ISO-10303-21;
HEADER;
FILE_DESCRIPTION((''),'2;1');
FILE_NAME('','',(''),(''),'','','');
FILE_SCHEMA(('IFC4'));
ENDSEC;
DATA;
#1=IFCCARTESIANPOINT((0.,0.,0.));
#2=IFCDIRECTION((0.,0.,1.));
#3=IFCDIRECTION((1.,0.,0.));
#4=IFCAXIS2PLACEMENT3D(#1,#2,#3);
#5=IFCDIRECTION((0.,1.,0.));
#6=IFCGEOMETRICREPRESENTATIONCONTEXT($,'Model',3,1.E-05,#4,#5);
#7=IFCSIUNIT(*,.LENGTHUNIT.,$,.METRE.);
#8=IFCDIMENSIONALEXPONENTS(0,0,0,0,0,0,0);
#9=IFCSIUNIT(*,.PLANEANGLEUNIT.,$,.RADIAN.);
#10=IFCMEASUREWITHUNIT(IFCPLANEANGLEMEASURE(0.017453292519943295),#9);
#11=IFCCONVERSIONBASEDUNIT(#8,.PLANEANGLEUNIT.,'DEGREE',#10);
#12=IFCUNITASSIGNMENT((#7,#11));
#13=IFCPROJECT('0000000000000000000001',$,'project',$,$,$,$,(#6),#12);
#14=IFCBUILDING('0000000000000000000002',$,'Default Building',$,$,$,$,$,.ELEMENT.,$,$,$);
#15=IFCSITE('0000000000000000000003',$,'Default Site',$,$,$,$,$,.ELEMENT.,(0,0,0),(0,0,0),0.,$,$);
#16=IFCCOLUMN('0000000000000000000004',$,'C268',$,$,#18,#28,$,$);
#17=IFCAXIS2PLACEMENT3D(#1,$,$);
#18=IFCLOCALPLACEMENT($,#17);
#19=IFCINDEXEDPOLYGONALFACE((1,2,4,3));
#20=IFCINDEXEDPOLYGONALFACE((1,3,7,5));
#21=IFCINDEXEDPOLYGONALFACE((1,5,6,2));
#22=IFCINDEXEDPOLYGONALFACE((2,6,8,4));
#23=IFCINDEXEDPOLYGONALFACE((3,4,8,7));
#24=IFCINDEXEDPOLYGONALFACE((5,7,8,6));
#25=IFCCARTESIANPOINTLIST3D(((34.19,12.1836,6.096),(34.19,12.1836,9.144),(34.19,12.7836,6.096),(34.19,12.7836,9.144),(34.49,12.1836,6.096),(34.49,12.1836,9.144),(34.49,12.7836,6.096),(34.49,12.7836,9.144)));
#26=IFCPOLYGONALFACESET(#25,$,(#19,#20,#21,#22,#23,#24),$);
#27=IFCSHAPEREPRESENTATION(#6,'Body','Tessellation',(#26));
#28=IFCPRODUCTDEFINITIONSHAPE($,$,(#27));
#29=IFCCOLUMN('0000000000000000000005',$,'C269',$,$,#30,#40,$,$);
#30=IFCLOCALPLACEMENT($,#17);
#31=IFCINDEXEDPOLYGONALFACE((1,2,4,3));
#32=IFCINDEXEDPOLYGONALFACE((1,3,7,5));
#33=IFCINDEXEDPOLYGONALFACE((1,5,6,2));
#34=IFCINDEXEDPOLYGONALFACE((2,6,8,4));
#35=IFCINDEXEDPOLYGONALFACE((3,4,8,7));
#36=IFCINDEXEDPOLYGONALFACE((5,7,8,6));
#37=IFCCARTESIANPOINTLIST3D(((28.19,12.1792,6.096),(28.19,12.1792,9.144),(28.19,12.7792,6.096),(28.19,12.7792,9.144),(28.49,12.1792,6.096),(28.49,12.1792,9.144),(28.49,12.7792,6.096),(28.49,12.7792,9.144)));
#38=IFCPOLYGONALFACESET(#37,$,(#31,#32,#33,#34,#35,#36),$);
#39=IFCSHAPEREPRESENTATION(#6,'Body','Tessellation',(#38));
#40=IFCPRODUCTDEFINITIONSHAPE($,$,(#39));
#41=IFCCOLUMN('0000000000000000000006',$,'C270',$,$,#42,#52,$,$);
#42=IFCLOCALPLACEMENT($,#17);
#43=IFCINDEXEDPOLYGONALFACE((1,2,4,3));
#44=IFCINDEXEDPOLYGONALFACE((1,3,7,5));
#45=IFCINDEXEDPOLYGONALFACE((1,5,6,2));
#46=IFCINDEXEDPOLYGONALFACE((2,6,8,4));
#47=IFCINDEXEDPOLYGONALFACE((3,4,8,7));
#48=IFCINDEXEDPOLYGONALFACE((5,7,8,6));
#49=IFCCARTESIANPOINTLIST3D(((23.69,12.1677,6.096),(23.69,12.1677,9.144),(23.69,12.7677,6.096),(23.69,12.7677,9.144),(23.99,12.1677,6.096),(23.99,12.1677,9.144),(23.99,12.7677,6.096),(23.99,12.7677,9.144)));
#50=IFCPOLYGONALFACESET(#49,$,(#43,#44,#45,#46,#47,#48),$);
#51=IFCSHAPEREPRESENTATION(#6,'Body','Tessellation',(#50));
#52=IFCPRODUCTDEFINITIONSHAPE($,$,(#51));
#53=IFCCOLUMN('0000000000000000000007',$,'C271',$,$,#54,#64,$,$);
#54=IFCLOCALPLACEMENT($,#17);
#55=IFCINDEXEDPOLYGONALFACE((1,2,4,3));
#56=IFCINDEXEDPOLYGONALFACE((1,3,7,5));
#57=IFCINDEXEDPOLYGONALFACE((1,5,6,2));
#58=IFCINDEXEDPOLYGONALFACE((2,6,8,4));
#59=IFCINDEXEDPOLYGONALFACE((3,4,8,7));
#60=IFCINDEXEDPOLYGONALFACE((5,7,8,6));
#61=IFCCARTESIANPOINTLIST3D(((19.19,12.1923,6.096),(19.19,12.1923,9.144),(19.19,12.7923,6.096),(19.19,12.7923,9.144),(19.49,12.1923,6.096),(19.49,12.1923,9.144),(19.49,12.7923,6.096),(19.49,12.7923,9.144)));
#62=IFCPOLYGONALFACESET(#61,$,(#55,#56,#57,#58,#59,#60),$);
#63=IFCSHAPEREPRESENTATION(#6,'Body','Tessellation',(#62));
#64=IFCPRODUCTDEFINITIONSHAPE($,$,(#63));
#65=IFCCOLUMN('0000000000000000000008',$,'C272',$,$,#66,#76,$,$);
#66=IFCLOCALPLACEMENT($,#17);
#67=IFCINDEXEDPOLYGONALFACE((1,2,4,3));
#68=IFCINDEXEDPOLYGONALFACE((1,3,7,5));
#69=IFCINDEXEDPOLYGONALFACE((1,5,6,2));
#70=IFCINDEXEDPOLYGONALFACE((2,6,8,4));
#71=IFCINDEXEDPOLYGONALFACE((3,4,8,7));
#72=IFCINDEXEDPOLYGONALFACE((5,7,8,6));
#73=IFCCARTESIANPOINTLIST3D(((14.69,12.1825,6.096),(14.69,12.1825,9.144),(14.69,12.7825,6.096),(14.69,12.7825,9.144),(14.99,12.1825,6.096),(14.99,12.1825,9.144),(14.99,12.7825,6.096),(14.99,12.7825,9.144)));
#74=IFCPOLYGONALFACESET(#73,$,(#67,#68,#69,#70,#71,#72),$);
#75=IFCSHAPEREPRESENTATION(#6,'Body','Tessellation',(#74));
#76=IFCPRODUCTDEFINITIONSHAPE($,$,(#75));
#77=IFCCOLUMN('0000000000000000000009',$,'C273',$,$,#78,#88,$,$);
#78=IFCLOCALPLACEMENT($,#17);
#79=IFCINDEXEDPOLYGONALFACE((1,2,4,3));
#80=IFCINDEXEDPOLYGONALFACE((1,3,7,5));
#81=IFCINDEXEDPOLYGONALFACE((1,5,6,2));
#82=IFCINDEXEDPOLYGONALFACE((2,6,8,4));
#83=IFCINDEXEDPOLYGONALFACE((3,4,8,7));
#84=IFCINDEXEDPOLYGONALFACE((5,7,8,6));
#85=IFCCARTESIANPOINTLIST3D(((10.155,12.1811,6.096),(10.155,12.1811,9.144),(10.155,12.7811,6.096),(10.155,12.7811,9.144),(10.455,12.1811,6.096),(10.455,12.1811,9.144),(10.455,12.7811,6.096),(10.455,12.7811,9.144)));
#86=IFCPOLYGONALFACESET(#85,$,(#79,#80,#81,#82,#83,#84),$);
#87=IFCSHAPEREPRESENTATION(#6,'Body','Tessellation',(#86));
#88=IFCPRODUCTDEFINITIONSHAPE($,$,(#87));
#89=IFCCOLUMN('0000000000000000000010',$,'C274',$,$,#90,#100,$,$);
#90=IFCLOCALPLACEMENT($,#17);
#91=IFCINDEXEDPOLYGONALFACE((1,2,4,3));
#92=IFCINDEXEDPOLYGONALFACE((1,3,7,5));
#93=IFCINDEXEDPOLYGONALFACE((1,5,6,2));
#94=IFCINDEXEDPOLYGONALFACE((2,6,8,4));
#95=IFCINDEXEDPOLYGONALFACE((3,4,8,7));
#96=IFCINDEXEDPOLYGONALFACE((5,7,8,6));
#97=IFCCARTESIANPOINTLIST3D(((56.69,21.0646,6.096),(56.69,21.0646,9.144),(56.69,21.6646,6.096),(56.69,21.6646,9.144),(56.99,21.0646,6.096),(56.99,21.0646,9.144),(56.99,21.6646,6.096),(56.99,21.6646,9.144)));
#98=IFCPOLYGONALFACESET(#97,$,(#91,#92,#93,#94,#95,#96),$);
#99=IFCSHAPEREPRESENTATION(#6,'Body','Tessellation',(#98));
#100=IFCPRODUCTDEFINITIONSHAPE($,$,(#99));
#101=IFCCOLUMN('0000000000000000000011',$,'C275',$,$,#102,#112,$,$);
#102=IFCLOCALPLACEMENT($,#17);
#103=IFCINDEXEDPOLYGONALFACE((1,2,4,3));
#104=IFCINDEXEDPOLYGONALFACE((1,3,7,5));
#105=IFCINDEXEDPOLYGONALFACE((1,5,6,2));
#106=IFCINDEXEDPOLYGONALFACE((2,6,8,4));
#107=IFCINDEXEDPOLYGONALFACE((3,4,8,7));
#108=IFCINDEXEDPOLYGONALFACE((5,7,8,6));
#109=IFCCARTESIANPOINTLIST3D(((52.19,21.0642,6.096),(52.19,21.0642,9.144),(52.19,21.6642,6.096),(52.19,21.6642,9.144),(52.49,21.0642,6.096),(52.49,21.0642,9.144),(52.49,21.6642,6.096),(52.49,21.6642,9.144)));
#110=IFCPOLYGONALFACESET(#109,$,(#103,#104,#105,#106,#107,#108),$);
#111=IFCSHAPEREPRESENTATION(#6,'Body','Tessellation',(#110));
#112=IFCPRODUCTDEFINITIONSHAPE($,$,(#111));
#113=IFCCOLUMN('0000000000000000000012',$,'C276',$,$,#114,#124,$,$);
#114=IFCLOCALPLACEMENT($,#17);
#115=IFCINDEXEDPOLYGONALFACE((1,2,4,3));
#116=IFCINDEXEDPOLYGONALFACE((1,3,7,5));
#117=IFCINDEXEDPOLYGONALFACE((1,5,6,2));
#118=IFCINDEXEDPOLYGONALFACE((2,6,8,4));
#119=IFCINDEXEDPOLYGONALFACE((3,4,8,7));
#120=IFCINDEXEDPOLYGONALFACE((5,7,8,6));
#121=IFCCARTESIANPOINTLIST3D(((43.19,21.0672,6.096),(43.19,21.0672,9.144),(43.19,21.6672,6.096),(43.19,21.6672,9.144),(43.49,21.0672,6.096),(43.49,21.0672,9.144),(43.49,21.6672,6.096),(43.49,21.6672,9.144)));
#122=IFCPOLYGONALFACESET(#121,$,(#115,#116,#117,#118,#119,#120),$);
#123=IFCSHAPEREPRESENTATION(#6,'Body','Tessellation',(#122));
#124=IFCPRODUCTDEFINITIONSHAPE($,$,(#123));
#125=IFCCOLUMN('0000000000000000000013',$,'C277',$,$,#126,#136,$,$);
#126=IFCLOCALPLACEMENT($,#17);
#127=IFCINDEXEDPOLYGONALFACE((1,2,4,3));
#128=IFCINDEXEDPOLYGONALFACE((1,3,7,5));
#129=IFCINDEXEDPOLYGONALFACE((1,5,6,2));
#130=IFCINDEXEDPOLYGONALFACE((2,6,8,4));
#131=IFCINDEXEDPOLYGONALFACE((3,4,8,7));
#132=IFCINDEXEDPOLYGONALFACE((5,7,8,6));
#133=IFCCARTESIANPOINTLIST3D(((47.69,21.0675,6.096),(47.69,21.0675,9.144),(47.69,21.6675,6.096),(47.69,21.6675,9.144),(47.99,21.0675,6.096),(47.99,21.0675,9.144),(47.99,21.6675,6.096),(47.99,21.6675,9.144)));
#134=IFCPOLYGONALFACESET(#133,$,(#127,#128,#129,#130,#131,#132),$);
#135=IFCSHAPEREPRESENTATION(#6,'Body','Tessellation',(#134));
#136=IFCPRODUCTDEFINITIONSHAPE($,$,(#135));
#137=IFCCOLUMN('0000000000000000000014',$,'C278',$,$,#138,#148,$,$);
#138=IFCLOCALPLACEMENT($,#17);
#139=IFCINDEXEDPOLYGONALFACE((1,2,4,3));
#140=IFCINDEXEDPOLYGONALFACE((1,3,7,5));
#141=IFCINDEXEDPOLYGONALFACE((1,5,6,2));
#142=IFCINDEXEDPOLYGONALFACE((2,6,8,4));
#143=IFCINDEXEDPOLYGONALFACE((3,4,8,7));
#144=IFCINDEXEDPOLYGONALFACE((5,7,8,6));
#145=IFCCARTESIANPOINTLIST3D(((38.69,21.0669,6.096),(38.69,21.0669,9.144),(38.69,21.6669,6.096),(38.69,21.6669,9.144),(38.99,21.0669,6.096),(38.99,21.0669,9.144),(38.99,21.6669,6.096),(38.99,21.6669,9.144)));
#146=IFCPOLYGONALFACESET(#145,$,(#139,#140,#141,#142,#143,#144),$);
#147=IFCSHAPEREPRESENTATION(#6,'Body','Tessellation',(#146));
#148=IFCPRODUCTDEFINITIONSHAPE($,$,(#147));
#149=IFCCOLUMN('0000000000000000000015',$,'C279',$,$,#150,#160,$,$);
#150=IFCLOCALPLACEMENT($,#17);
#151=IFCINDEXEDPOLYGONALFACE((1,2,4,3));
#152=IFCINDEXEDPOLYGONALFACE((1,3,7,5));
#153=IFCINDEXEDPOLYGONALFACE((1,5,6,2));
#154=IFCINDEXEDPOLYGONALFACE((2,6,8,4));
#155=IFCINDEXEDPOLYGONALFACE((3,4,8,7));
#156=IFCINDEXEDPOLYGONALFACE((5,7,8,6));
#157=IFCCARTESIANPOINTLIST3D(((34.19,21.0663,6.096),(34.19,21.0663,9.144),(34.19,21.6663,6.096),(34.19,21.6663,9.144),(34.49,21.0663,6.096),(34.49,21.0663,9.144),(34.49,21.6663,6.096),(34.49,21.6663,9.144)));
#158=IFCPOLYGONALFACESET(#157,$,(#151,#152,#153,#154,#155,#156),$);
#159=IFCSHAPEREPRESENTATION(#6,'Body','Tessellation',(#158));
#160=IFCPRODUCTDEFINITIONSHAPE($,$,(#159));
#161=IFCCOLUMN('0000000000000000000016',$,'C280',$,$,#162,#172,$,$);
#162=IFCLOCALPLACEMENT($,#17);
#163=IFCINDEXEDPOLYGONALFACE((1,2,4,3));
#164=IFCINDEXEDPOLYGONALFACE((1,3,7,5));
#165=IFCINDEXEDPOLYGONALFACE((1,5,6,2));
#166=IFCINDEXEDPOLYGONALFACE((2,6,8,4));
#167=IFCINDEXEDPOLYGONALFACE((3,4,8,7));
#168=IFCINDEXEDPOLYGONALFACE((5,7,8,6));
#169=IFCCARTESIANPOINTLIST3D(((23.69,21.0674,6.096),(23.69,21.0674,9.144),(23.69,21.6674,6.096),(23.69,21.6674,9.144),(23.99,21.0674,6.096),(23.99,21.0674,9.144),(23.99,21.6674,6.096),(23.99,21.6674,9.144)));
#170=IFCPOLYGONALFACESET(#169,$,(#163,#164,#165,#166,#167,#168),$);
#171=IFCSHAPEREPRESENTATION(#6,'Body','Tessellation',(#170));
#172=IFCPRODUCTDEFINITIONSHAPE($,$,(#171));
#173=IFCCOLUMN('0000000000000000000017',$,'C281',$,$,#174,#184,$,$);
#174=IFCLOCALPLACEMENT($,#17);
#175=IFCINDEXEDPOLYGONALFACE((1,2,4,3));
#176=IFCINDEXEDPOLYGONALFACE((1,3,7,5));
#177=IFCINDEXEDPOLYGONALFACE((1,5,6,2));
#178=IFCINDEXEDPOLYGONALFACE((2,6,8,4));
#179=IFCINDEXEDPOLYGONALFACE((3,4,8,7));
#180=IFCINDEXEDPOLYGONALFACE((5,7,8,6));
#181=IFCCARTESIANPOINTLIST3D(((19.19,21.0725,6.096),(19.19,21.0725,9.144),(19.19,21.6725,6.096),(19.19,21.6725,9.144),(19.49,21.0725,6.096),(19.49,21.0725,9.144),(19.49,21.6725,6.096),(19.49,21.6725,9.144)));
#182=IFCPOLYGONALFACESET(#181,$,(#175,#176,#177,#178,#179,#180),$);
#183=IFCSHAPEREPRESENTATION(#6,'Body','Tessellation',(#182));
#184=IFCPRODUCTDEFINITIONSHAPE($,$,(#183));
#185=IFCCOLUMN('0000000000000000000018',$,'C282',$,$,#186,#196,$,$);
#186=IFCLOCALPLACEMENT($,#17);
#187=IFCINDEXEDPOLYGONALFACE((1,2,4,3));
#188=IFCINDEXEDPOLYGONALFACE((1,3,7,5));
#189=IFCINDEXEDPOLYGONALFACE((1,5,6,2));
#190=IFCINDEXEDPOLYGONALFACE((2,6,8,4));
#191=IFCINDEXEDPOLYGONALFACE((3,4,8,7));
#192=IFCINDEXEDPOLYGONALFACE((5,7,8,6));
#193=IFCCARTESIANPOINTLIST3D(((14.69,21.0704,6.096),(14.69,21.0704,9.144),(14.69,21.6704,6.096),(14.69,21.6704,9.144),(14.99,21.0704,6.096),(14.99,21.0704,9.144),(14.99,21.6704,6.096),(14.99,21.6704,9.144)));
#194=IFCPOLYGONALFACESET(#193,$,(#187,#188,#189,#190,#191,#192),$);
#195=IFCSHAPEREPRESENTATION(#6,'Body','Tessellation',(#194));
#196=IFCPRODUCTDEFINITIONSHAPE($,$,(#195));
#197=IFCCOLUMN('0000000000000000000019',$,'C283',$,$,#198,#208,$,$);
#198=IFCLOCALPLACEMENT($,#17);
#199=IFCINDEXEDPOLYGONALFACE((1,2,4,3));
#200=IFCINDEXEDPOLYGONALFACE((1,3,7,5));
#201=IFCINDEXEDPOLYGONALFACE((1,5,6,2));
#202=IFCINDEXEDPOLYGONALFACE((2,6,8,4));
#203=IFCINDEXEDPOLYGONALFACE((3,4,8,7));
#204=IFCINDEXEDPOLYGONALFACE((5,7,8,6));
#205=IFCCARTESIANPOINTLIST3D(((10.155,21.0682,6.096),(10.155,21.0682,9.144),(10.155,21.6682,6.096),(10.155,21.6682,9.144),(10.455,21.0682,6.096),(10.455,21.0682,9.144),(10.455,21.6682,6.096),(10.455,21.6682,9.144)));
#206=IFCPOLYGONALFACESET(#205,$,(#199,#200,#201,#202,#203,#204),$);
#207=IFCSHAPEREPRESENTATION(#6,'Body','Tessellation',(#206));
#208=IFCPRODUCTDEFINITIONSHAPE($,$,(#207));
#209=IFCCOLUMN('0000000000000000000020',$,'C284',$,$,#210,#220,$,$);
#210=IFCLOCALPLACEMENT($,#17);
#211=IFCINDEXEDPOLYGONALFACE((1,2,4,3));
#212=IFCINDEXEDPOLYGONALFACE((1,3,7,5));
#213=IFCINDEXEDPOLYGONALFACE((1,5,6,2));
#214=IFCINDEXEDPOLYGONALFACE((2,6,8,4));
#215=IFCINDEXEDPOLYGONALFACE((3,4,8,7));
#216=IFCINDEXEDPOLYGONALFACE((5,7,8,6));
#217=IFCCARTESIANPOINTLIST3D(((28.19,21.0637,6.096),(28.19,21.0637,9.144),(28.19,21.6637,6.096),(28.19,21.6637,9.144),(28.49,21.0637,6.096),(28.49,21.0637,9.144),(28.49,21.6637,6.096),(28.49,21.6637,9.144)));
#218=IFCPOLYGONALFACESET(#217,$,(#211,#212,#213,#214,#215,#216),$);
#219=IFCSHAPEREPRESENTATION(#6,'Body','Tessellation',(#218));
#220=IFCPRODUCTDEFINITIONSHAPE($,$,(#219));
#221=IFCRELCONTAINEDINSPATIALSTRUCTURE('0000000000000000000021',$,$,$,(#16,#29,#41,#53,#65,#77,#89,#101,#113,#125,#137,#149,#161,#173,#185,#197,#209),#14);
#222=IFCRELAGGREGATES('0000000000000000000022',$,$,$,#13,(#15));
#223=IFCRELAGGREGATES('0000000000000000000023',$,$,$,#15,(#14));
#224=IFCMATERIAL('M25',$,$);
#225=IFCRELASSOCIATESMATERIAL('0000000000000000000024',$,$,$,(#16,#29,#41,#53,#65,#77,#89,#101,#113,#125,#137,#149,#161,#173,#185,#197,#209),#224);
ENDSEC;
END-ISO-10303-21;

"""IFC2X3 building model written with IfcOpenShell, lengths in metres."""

from ifc_helpers import new_model, entity, si_unit, converted_unit, direction, frame, frame_2d, origin_with_axes, place, context, project, spatial, rectangle, extrude, material, element, save


model = new_model("IFC2X3")

# Units and contexts
model_context = context("Model", 3, precision=1e-05, world=origin_with_axes(), true_north=direction((0.0, 1.0, 0.0)))
ifc_project = project(units=[si_unit("LENGTHUNIT", "METRE"), converted_unit("PLANEANGLEUNIT", "DEGREE", entity("IfcPlaneAngleMeasure", 0.017453292519943295), si_unit("PLANEANGLEUNIT", "RADIAN"), dimensions=[0, 0, 0, 0, 0, 0, 0])], contexts=[model_context])

# Site, building
site = spatial("IfcSite", under=ifc_project, Name="Default Site", CompositionType="ELEMENT", RefLatitude=(0, 0, 0), RefLongitude=(0, 0, 0), RefElevation=0.0)
building = spatial("IfcBuilding", under=site, Name="Default Building", CompositionType="ELEMENT")

# Columns
ifc_material = material(Name="M25")
placement = place(None, origin_with_axes())
element("IfcColumn", 1, at=placement, inside=building, material=ifc_material, Name="C268", context=model_context, shape_type="SweptSolid", body=[
    extrude(rectangle(XDim=0.3, YDim=0.6, at=frame_2d((0.0, 0.0), x_axis=(1.0, 0.0, 0.0))), frame((34.34, 12.4836, 6.096), z_axis=(0.0, 0.0, 1.0), x_axis=(1.0, 0.0, 0.0)), (0.0, 0.0, 1.0), 3.048),
])
element("IfcColumn", 2, at=placement, inside=building, material=ifc_material, Name="C269", context=model_context, shape_type="SweptSolid", body=[
    extrude(rectangle(XDim=0.3, YDim=0.6, at=frame_2d((0.0, 0.0), x_axis=(1.0, 0.0, 0.0))), frame((28.34, 12.4792, 6.096), z_axis=(0.0, 0.0, 1.0), x_axis=(1.0, 0.0, 0.0)), (0.0, 0.0, 1.0), 3.048),
])
element("IfcColumn", 3, at=placement, inside=building, material=ifc_material, Name="C270", context=model_context, shape_type="SweptSolid", body=[
    extrude(rectangle(XDim=0.3, YDim=0.6, at=frame_2d((0.0, 0.0), x_axis=(1.0, 0.0, 0.0))), frame((23.84, 12.4677, 6.096), z_axis=(0.0, 0.0, 1.0), x_axis=(1.0, 0.0, 0.0)), (0.0, 0.0, 1.0), 3.048),
])
element("IfcColumn", 4, at=placement, inside=building, material=ifc_material, Name="C271", context=model_context, shape_type="SweptSolid", body=[
    extrude(rectangle(XDim=0.3, YDim=0.6, at=frame_2d((0.0, 0.0), x_axis=(1.0, 0.0, 0.0))), frame((19.34, 12.4923, 6.096), z_axis=(0.0, 0.0, 1.0), x_axis=(1.0, 0.0, 0.0)), (0.0, 0.0, 1.0), 3.048),
])
element("IfcColumn", 5, at=placement, inside=building, material=ifc_material, Name="C272", context=model_context, shape_type="SweptSolid", body=[
    extrude(rectangle(XDim=0.3, YDim=0.6, at=frame_2d((0.0, 0.0), x_axis=(1.0, 0.0, 0.0))), frame((14.84, 12.4825, 6.096), z_axis=(0.0, 0.0, 1.0), x_axis=(1.0, 0.0, 0.0)), (0.0, 0.0, 1.0), 3.048),
])
element("IfcColumn", 6, at=placement, inside=building, material=ifc_material, Name="C273", context=model_context, shape_type="SweptSolid", body=[
    extrude(rectangle(XDim=0.3, YDim=0.6, at=frame_2d((0.0, 0.0), x_axis=(1.0, 0.0, 0.0))), frame((10.305, 12.4811, 6.096), z_axis=(0.0, 0.0, 1.0), x_axis=(1.0, 0.0, 0.0)), (0.0, 0.0, 1.0), 3.048),
])
element("IfcColumn", 7, at=placement, inside=building, material=ifc_material, Name="C274", context=model_context, shape_type="SweptSolid", body=[
    extrude(rectangle(XDim=0.3, YDim=0.6, at=frame_2d((0.0, 0.0), x_axis=(1.0, 0.0, 0.0))), frame((56.84, 21.3646, 6.096), z_axis=(0.0, 0.0, 1.0), x_axis=(1.0, 0.0, 0.0)), (0.0, 0.0, 1.0), 3.048),
])
element("IfcColumn", 8, at=placement, inside=building, material=ifc_material, Name="C275", context=model_context, shape_type="SweptSolid", body=[
    extrude(rectangle(XDim=0.3, YDim=0.6, at=frame_2d((0.0, 0.0), x_axis=(1.0, 0.0, 0.0))), frame((52.34, 21.3642, 6.096), z_axis=(0.0, 0.0, 1.0), x_axis=(1.0, 0.0, 0.0)), (0.0, 0.0, 1.0), 3.048),
])
element("IfcColumn", 9, at=placement, inside=building, material=ifc_material, Name="C276", context=model_context, shape_type="SweptSolid", body=[
    extrude(rectangle(XDim=0.3, YDim=0.6, at=frame_2d((0.0, 0.0), x_axis=(1.0, 0.0, 0.0))), frame((43.34, 21.3672, 6.096), z_axis=(0.0, 0.0, 1.0), x_axis=(1.0, 0.0, 0.0)), (0.0, 0.0, 1.0), 3.048),
])
element("IfcColumn", 10, at=placement, inside=building, material=ifc_material, Name="C277", context=model_context, shape_type="SweptSolid", body=[
    extrude(rectangle(XDim=0.3, YDim=0.6, at=frame_2d((0.0, 0.0), x_axis=(1.0, 0.0, 0.0))), frame((47.84, 21.3675, 6.096), z_axis=(0.0, 0.0, 1.0), x_axis=(1.0, 0.0, 0.0)), (0.0, 0.0, 1.0), 3.048),
])
element("IfcColumn", 11, at=placement, inside=building, material=ifc_material, Name="C278", context=model_context, shape_type="SweptSolid", body=[
    extrude(rectangle(XDim=0.3, YDim=0.6, at=frame_2d((0.0, 0.0), x_axis=(1.0, 0.0, 0.0))), frame((38.84, 21.3669, 6.096), z_axis=(0.0, 0.0, 1.0), x_axis=(1.0, 0.0, 0.0)), (0.0, 0.0, 1.0), 3.048),
])
element("IfcColumn", 12, at=placement, inside=building, material=ifc_material, Name="C279", context=model_context, shape_type="SweptSolid", body=[
    extrude(rectangle(XDim=0.3, YDim=0.6, at=frame_2d((0.0, 0.0), x_axis=(1.0, 0.0, 0.0))), frame((34.34, 21.3663, 6.096), z_axis=(0.0, 0.0, 1.0), x_axis=(1.0, 0.0, 0.0)), (0.0, 0.0, 1.0), 3.048),
])
element("IfcColumn", 13, at=placement, inside=building, material=ifc_material, Name="C280", context=model_context, shape_type="SweptSolid", body=[
    extrude(rectangle(XDim=0.3, YDim=0.6, at=frame_2d((0.0, 0.0), x_axis=(1.0, 0.0, 0.0))), frame((23.84, 21.3674, 6.096), z_axis=(0.0, 0.0, 1.0), x_axis=(1.0, 0.0, 0.0)), (0.0, 0.0, 1.0), 3.048),
])
element("IfcColumn", 14, at=placement, inside=building, material=ifc_material, Name="C281", context=model_context, shape_type="SweptSolid", body=[
    extrude(rectangle(XDim=0.3, YDim=0.6, at=frame_2d((0.0, 0.0), x_axis=(1.0, 0.0, 0.0))), frame((19.34, 21.3725, 6.096), z_axis=(0.0, 0.0, 1.0), x_axis=(1.0, 0.0, 0.0)), (0.0, 0.0, 1.0), 3.048),
])
element("IfcColumn", 15, at=placement, inside=building, material=ifc_material, Name="C282", context=model_context, shape_type="SweptSolid", body=[
    extrude(rectangle(XDim=0.3, YDim=0.6, at=frame_2d((0.0, 0.0), x_axis=(1.0, 0.0, 0.0))), frame((14.84, 21.3704, 6.096), z_axis=(0.0, 0.0, 1.0), x_axis=(1.0, 0.0, 0.0)), (0.0, 0.0, 1.0), 3.048),
])
element("IfcColumn", 16, at=placement, inside=building, material=ifc_material, Name="C283", context=model_context, shape_type="SweptSolid", body=[
    extrude(rectangle(XDim=0.3, YDim=0.6, at=frame_2d((0.0, 0.0), x_axis=(1.0, 0.0, 0.0))), frame((10.305, 21.3682, 6.096), z_axis=(0.0, 0.0, 1.0), x_axis=(1.0, 0.0, 0.0)), (0.0, 0.0, 1.0), 3.048),
])
element("IfcColumn", 17, at=placement, inside=building, material=ifc_material, Name="C284", context=model_context, shape_type="SweptSolid", body=[
    extrude(rectangle(XDim=0.3, YDim=0.6, at=frame_2d((0.0, 0.0), x_axis=(1.0, 0.0, 0.0))), frame((28.34, 21.3637, 6.096), z_axis=(0.0, 0.0, 1.0), x_axis=(1.0, 0.0, 0.0)), (0.0, 0.0, 1.0), 3.048),
])

save(model, "model.ifc")
